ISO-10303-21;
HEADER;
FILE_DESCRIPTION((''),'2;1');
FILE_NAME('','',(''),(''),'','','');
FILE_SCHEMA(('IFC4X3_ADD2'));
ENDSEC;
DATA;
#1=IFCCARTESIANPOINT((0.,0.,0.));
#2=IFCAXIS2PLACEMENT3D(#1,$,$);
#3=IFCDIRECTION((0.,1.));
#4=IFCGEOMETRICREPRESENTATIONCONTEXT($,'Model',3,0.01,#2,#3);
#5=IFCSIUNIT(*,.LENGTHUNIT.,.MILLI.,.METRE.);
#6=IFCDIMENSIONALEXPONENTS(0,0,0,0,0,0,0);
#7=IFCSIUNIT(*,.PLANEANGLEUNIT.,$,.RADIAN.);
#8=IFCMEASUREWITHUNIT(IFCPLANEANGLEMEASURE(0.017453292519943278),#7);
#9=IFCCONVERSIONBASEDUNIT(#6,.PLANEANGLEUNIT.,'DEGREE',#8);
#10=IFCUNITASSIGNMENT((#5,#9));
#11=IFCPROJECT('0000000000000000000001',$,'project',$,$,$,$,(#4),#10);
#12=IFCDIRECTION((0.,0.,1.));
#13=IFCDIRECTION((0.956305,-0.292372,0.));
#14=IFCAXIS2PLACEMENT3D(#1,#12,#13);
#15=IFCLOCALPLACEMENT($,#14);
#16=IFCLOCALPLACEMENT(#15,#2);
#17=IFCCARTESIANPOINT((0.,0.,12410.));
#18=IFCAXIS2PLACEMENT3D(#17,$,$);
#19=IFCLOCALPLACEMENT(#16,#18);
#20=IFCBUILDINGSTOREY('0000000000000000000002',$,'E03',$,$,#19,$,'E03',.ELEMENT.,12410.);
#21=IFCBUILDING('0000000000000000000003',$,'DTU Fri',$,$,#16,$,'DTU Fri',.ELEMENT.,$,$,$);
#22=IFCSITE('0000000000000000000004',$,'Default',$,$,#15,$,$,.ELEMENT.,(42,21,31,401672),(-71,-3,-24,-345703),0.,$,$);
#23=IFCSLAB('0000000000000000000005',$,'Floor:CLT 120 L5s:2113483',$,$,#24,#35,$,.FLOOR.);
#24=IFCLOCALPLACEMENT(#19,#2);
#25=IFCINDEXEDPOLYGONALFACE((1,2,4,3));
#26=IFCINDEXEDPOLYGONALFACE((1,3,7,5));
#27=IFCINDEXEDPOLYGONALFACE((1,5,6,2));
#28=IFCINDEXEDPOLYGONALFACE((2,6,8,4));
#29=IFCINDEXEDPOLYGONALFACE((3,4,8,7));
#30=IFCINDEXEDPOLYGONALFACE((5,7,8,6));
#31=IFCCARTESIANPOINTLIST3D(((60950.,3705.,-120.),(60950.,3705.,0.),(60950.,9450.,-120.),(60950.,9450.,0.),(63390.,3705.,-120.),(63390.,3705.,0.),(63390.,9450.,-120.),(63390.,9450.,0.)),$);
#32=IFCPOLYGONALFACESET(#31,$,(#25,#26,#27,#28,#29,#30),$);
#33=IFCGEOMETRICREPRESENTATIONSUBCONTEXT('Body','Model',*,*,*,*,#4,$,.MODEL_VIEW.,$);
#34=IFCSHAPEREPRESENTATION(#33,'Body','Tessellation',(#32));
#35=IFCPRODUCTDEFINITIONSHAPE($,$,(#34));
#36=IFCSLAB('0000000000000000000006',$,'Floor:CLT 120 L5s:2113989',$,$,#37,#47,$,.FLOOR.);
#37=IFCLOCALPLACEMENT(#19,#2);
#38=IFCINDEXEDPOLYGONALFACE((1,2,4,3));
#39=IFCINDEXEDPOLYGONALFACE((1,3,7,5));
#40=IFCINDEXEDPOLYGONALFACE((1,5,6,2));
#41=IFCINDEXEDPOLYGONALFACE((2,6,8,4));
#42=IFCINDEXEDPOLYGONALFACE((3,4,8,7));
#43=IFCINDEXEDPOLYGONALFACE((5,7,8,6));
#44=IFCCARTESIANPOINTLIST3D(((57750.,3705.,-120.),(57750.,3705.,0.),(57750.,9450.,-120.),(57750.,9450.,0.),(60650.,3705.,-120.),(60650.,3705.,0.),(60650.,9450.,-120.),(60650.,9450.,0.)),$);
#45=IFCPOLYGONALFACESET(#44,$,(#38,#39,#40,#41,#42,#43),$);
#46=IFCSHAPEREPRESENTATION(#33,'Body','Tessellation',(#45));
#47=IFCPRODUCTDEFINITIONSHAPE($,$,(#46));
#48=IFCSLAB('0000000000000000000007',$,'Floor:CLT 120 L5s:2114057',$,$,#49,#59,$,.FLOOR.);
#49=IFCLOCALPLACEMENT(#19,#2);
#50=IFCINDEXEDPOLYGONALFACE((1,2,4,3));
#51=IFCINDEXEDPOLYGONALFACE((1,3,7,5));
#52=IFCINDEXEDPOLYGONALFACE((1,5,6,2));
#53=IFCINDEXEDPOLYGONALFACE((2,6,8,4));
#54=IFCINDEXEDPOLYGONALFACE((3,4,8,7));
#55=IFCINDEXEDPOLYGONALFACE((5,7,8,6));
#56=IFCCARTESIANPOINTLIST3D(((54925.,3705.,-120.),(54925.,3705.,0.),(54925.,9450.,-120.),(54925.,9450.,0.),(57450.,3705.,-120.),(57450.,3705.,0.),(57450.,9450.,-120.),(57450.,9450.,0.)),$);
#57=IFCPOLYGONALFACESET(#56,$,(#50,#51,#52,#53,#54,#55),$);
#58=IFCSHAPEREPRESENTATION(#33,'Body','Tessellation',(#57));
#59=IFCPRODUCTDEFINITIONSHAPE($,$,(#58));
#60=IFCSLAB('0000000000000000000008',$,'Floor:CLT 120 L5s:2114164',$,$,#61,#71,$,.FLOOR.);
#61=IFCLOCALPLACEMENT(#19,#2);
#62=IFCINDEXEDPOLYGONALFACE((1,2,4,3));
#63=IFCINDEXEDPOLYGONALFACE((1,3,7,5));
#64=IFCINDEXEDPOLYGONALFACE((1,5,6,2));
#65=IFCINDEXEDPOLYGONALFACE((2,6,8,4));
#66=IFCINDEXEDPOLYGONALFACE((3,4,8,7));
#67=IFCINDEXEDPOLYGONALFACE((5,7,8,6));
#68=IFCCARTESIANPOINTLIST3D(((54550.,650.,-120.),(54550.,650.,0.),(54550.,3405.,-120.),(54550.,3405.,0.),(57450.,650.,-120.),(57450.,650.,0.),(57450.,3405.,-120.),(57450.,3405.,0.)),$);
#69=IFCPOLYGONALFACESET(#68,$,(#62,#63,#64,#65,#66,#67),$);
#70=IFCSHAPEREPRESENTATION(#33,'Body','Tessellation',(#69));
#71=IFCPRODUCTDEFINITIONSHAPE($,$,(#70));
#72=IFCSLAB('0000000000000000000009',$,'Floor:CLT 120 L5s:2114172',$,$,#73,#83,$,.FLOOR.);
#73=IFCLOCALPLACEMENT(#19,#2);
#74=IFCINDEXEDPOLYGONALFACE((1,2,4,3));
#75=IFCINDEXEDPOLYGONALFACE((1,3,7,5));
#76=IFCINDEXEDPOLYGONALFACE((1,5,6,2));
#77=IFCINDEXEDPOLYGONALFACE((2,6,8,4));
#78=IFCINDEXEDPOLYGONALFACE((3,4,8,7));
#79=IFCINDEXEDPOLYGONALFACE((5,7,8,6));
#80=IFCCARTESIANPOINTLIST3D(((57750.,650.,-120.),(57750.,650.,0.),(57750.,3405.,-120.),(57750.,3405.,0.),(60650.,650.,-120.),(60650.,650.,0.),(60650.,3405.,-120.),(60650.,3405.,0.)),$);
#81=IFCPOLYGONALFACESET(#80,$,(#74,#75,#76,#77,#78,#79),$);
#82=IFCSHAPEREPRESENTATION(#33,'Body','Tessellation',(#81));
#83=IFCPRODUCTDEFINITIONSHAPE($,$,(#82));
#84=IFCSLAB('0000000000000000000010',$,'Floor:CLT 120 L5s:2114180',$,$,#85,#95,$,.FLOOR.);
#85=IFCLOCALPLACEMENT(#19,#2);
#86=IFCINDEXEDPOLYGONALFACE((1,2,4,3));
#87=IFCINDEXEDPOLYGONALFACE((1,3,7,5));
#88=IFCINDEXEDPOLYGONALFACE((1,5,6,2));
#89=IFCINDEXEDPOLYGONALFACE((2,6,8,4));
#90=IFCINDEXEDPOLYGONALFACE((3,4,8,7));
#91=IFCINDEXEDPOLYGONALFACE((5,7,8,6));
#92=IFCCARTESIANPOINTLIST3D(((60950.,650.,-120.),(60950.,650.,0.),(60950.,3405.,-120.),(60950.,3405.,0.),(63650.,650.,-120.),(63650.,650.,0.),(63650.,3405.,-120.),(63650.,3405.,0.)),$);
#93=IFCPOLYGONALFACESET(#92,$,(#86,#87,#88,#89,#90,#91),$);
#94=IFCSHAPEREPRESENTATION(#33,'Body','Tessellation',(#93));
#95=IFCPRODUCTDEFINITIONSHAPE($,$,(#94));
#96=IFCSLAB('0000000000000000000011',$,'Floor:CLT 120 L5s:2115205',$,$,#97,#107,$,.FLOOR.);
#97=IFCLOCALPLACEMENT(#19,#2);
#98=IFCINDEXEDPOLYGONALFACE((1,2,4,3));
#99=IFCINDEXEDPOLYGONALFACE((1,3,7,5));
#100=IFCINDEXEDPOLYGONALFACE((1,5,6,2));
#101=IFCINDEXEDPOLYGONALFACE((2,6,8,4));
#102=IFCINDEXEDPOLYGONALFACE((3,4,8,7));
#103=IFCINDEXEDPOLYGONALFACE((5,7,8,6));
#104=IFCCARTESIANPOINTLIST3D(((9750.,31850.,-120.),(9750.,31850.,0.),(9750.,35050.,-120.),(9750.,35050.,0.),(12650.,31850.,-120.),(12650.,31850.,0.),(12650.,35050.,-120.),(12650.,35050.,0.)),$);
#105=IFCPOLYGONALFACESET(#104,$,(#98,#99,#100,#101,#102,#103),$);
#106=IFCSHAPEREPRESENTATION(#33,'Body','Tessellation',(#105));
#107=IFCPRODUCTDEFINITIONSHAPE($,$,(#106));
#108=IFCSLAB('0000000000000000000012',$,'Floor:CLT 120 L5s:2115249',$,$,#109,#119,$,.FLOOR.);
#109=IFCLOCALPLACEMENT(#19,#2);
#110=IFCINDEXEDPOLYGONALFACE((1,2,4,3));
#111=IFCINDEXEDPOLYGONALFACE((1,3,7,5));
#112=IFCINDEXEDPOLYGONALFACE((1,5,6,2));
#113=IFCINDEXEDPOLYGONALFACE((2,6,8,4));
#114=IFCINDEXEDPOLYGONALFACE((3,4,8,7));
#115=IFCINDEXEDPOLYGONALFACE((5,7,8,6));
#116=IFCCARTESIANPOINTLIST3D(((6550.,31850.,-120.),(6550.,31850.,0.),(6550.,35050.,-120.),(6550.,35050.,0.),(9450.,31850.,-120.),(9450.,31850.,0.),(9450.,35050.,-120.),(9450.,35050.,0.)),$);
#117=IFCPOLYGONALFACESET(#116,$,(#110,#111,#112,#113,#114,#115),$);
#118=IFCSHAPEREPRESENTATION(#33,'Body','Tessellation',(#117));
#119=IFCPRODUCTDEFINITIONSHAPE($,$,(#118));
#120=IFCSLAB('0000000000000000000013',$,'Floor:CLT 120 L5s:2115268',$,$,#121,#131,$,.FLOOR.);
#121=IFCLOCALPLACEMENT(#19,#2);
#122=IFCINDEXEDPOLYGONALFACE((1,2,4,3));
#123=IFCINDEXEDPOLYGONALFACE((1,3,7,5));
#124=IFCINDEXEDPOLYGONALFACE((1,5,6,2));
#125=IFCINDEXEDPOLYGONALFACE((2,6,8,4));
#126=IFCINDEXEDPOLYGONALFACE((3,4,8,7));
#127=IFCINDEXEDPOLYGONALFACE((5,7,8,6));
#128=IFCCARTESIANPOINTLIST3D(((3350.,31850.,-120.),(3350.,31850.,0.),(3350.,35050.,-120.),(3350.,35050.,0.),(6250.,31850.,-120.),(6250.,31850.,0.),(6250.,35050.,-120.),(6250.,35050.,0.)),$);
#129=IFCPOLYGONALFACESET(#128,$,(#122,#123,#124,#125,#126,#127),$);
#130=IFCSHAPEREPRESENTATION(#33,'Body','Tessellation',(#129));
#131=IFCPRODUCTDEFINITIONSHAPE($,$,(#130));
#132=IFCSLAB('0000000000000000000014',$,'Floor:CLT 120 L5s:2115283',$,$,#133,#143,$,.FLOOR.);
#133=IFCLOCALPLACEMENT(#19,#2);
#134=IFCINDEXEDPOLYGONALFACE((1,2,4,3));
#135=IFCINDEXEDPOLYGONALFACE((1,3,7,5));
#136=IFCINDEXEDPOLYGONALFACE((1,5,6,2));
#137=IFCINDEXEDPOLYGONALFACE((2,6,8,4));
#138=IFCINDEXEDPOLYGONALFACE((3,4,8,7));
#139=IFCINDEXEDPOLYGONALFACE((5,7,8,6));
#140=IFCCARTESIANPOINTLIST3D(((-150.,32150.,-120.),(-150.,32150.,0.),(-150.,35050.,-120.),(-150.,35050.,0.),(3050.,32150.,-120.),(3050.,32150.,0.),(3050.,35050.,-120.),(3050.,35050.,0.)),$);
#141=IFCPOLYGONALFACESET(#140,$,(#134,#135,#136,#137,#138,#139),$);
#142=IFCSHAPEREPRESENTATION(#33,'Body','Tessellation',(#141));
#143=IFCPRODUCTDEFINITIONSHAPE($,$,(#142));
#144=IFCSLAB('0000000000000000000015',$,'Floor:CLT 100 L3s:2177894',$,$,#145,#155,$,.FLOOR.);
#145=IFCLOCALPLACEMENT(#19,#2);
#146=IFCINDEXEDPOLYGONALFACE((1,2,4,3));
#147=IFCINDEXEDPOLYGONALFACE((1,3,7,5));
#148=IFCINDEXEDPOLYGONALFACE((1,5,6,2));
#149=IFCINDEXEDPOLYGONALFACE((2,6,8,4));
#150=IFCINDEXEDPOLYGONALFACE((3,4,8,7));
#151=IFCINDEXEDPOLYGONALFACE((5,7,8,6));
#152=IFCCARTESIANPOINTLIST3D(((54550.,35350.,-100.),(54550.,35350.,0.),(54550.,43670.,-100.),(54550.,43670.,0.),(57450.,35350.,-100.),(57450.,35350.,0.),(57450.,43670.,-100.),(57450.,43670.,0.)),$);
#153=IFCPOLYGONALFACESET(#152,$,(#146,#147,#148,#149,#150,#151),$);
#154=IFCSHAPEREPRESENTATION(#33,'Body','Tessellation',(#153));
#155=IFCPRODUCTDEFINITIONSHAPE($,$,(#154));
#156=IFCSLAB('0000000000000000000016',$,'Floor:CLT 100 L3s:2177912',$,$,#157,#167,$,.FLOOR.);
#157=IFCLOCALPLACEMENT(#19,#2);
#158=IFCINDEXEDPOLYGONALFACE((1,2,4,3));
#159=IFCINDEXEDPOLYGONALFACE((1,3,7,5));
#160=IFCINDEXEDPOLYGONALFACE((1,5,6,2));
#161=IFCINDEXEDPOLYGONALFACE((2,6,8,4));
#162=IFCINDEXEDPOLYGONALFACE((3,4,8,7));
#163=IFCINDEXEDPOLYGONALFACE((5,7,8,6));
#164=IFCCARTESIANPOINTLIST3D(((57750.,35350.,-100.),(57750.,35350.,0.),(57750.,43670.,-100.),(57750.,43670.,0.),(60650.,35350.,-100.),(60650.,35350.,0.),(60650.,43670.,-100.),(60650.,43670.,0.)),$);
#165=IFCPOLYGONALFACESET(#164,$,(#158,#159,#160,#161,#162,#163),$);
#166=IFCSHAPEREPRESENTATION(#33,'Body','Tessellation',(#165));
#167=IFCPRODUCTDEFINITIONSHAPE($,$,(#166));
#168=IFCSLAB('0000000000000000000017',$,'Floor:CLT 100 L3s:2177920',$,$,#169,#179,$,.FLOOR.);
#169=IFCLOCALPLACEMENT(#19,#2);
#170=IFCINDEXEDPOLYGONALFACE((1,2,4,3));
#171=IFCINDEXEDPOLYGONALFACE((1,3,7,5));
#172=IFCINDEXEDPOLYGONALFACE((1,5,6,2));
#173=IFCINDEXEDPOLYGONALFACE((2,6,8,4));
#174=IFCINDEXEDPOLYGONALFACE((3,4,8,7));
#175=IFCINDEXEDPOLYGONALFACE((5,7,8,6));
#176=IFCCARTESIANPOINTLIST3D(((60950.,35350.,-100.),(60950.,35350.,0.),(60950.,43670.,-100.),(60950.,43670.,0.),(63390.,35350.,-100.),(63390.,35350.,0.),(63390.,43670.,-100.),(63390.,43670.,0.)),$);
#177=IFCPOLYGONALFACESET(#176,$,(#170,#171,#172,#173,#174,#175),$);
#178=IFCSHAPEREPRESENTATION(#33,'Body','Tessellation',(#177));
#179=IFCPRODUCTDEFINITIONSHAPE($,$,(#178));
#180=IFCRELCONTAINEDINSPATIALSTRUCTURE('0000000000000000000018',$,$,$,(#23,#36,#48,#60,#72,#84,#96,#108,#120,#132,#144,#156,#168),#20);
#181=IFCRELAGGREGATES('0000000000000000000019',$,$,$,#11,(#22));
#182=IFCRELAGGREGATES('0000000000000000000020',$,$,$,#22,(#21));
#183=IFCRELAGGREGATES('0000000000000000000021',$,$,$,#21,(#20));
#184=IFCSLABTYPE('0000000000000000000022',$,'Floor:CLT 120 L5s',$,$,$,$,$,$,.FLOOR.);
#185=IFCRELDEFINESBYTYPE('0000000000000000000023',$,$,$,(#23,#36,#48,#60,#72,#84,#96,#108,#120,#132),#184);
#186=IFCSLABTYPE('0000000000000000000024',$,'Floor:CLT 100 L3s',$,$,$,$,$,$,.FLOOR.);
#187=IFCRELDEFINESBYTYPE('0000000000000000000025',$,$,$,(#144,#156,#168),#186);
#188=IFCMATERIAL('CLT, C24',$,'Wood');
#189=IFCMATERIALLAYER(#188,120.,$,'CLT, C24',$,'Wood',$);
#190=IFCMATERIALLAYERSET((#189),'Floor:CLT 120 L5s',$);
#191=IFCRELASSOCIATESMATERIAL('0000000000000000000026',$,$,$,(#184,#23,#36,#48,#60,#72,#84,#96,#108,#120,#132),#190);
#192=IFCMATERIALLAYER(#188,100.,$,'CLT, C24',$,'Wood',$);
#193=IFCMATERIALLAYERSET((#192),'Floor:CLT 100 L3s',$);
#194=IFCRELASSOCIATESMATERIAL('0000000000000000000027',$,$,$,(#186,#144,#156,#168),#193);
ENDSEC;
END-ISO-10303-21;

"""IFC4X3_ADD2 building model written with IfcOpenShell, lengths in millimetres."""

from ifc_helpers import new_model, entity, si_unit, converted_unit, direction, frame, frame_2d, origin, origin_2d_with_axis, place, context, subcontext, project, spatial, rectangle, extrude, material, layer, layer_set, layer_usage, type_object, element, save


model = new_model("IFC4X3_ADD2")

# Units and contexts
model_context = context("Model", 3, precision=0.01, world=origin(), true_north=direction((0.0, 1.0)))
body_context = subcontext(model_context, "Body", "Model", "MODEL_VIEW")
ifc_project = project(units=[si_unit("LENGTHUNIT", "METRE", prefix="MILLI"), converted_unit("PLANEANGLEUNIT", "DEGREE", entity("IfcPlaneAngleMeasure", 0.017453292519943278), si_unit("PLANEANGLEUNIT", "RADIAN"), dimensions=[0, 0, 0, 0, 0, 0, 0])], contexts=[model_context])

# Site, building, storey
site_placement = place(None, frame((0.0, 0.0, 0.0), z_axis=(0.0, 0.0, 1.0), x_axis=(0.956305, -0.292372, 0.0)))
site = spatial("IfcSite", under=ifc_project, at=site_placement, Name="Default", CompositionType="ELEMENT", RefLatitude=(42, 21, 31, 401672), RefLongitude=(-71, -3, -24, -345703), RefElevation=0.0)
building_placement = place(site_placement, origin())
building = spatial("IfcBuilding", under=site, at=building_placement, Name="DTU Fri", LongName="DTU Fri", CompositionType="ELEMENT")
storey_placement = place(building_placement, frame((0.0, 0.0, 12410.0)))
storey = spatial("IfcBuildingStorey", under=building, at=storey_placement, Name="E03", LongName="E03", CompositionType="ELEMENT", Elevation=12410.0)

# Slabs
ifc_material = material(Name="CLT, C24", Category="Wood")
ifc_layer_1 = layer(ifc_material, 120.0, Name="CLT, C24", Category="Wood")
ifc_layer_set_1 = layer_set([ifc_layer_1], Name="Floor:CLT 120 L5s")
ifc_layer_usage_1 = layer_usage(ifc_layer_set_1, "AXIS3", "POSITIVE", 0.0)
slab_type_1 = type_object("IfcSlabType", Name="Floor:CLT 120 L5s", PredefinedType="FLOOR", material=ifc_layer_set_1)
slab_1_placement = place(storey_placement, origin())
element("IfcSlab", 1, at=slab_1_placement, inside=storey, type_object=slab_type_1, material=ifc_layer_usage_1, Name="Floor:CLT 120 L5s:2113483", PredefinedType="FLOOR", context=body_context, shape_type="SweptSolid", body=[
    extrude(rectangle(XDim=5745.0, YDim=2440.0, at=frame_2d((0.0, 0.0), x_axis=(1.0, 0.0))), frame((62170.0, 6577.5, 0.0), z_axis=(0.0, 0.0, -1.0), x_axis=(0.0, 1.0, 0.0)), (0.0, 0.0, 1.0), 120.0),
])
ifc_layer_usage_2 = layer_usage(ifc_layer_set_1, "AXIS3", "POSITIVE", 0.0)
slab_2_placement = place(storey_placement, origin())
element("IfcSlab", 2, at=slab_2_placement, inside=storey, type_object=slab_type_1, material=ifc_layer_usage_2, Name="Floor:CLT 120 L5s:2113989", PredefinedType="FLOOR", context=body_context, shape_type="SweptSolid", body=[
    extrude(rectangle(XDim=5745.0, YDim=2900.0, at=frame_2d((0.0, 0.0), x_axis=(1.0, 0.0))), frame((59200.0, 6577.5, 0.0), z_axis=(0.0, 0.0, -1.0), x_axis=(0.0, 1.0, 0.0)), (0.0, 0.0, 1.0), 120.0),
])
ifc_layer_usage_3 = layer_usage(ifc_layer_set_1, "AXIS3", "POSITIVE", 0.0)
slab_3_placement = place(storey_placement, origin())
element("IfcSlab", 3, at=slab_3_placement, inside=storey, type_object=slab_type_1, material=ifc_layer_usage_3, Name="Floor:CLT 120 L5s:2114057", PredefinedType="FLOOR", context=body_context, shape_type="SweptSolid", body=[
    extrude(rectangle(XDim=5745.0, YDim=2525.0, at=frame_2d((0.0, 0.0), x_axis=(1.0, 0.0))), frame((56187.5, 6577.5, 0.0), z_axis=(0.0, 0.0, -1.0), x_axis=(0.0, 1.0, 0.0)), (0.0, 0.0, 1.0), 120.0),
])
ifc_layer_usage_4 = layer_usage(ifc_layer_set_1, "AXIS3", "POSITIVE", 0.0)
slab_4_placement = place(storey_placement, origin())
element("IfcSlab", 4, at=slab_4_placement, inside=storey, type_object=slab_type_1, material=ifc_layer_usage_4, Name="Floor:CLT 120 L5s:2114164", PredefinedType="FLOOR", context=body_context, shape_type="SweptSolid", body=[
    extrude(rectangle(XDim=2755.0, YDim=2900.0, at=origin_2d_with_axis()), frame((56000.0, 2027.5, 0.0), z_axis=(0.0, 0.0, -1.0), x_axis=(0.0, 1.0, 0.0)), (0.0, 0.0, 1.0), 120.0),
])
ifc_layer_usage_5 = layer_usage(ifc_layer_set_1, "AXIS3", "POSITIVE", 0.0)
slab_5_placement = place(storey_placement, origin())
element("IfcSlab", 5, at=slab_5_placement, inside=storey, type_object=slab_type_1, material=ifc_layer_usage_5, Name="Floor:CLT 120 L5s:2114172", PredefinedType="FLOOR", context=body_context, shape_type="SweptSolid", body=[
    extrude(rectangle(XDim=2755.0, YDim=2900.0, at=frame_2d((0.0, 0.0), x_axis=(1.0, 0.0))), frame((59200.0, 2027.5, 0.0), z_axis=(0.0, 0.0, -1.0), x_axis=(0.0, 1.0, 0.0)), (0.0, 0.0, 1.0), 120.0),
])
ifc_layer_usage_6 = layer_usage(ifc_layer_set_1, "AXIS3", "POSITIVE", 0.0)
slab_6_placement = place(storey_placement, origin())
element("IfcSlab", 6, at=slab_6_placement, inside=storey, type_object=slab_type_1, material=ifc_layer_usage_6, Name="Floor:CLT 120 L5s:2114180", PredefinedType="FLOOR", context=body_context, shape_type="SweptSolid", body=[
    extrude(rectangle(XDim=2755.0, YDim=2700.0, at=frame_2d((0.0, 0.0), x_axis=(1.0, 0.0))), frame((62300.0, 2027.5, 0.0), z_axis=(0.0, 0.0, -1.0), x_axis=(0.0, 1.0, 0.0)), (0.0, 0.0, 1.0), 120.0),
])
ifc_layer_usage_7 = layer_usage(ifc_layer_set_1, "AXIS3", "POSITIVE", 0.0)
slab_7_placement = place(storey_placement, origin())
element("IfcSlab", 7, at=slab_7_placement, inside=storey, type_object=slab_type_1, material=ifc_layer_usage_7, Name="Floor:CLT 120 L5s:2115205", PredefinedType="FLOOR", context=body_context, shape_type="SweptSolid", body=[
    extrude(rectangle(XDim=3200.0, YDim=2900.0, at=frame_2d((0.0, 0.0), x_axis=(1.0, 0.0))), frame((11200.0, 33450.0, 0.0), z_axis=(0.0, 0.0, -1.0), x_axis=(0.0, 1.0, 0.0)), (0.0, 0.0, 1.0), 120.0),
])
ifc_layer_usage_8 = layer_usage(ifc_layer_set_1, "AXIS3", "POSITIVE", 0.0)
slab_8_placement = place(storey_placement, origin())
element("IfcSlab", 8, at=slab_8_placement, inside=storey, type_object=slab_type_1, material=ifc_layer_usage_8, Name="Floor:CLT 120 L5s:2115249", PredefinedType="FLOOR", context=body_context, shape_type="SweptSolid", body=[
    extrude(rectangle(XDim=3200.0, YDim=2900.0, at=frame_2d((0.0, 0.0), x_axis=(1.0, 0.0))), frame((8000.0, 33450.0, 0.0), z_axis=(0.0, 0.0, -1.0), x_axis=(0.0, 1.0, 0.0)), (0.0, 0.0, 1.0), 120.0),
])
ifc_layer_usage_9 = layer_usage(ifc_layer_set_1, "AXIS3", "POSITIVE", 0.0)
slab_9_placement = place(storey_placement, origin())
element("IfcSlab", 9, at=slab_9_placement, inside=storey, type_object=slab_type_1, material=ifc_layer_usage_9, Name="Floor:CLT 120 L5s:2115268", PredefinedType="FLOOR", context=body_context, shape_type="SweptSolid", body=[
    extrude(rectangle(XDim=3200.0, YDim=2900.0, at=frame_2d((0.0, 0.0), x_axis=(1.0, 0.0))), frame((4800.0, 33450.0, 0.0), z_axis=(0.0, 0.0, -1.0), x_axis=(0.0, 1.0, 0.0)), (0.0, 0.0, 1.0), 120.0),
])
ifc_layer_usage_10 = layer_usage(ifc_layer_set_1, "AXIS3", "POSITIVE", 0.0)
slab_10_placement = place(storey_placement, origin())
element("IfcSlab", 10, at=slab_10_placement, inside=storey, type_object=slab_type_1, material=ifc_layer_usage_10, Name="Floor:CLT 120 L5s:2115283", PredefinedType="FLOOR", context=body_context, shape_type="SweptSolid", body=[
    extrude(rectangle(XDim=2900.0, YDim=3200.0, at=frame_2d((0.0, 0.0), x_axis=(1.0, 0.0))), frame((1450.0, 33600.0, 0.0), z_axis=(0.0, 0.0, -1.0), x_axis=(0.0, 1.0, 0.0)), (0.0, 0.0, 1.0), 120.0),
])
ifc_layer_2 = layer(ifc_material, 100.0, Name="CLT, C24", Category="Wood")
ifc_layer_set_2 = layer_set([ifc_layer_2], Name="Floor:CLT 100 L3s")
ifc_layer_usage_11 = layer_usage(ifc_layer_set_2, "AXIS3", "POSITIVE", 0.0)
slab_type_2 = type_object("IfcSlabType", Name="Floor:CLT 100 L3s", PredefinedType="FLOOR", material=ifc_layer_set_2)
slab_11_placement = place(storey_placement, origin())
element("IfcSlab", 11, at=slab_11_placement, inside=storey, type_object=slab_type_2, material=ifc_layer_usage_11, Name="Floor:CLT 100 L3s:2177894", PredefinedType="FLOOR", context=body_context, shape_type="SweptSolid", body=[
    extrude(rectangle(XDim=8320.0, YDim=2900.0, at=frame_2d((0.0, 0.0), x_axis=(1.0, 0.0))), frame((56000.0, 39510.0, 0.0), z_axis=(0.0, 0.0, -1.0), x_axis=(0.0, 1.0, 0.0)), (0.0, 0.0, 1.0), 100.0),
])
ifc_layer_usage_12 = layer_usage(ifc_layer_set_2, "AXIS3", "POSITIVE", 0.0)
slab_12_placement = place(storey_placement, origin())
element("IfcSlab", 12, at=slab_12_placement, inside=storey, type_object=slab_type_2, material=ifc_layer_usage_12, Name="Floor:CLT 100 L3s:2177912", PredefinedType="FLOOR", context=body_context, shape_type="SweptSolid", body=[
    extrude(rectangle(XDim=8320.0, YDim=2900.0, at=frame_2d((0.0, 0.0), x_axis=(1.0, 0.0))), frame((59200.0, 39510.0, 0.0), z_axis=(0.0, 0.0, -1.0), x_axis=(0.0, 1.0, 0.0)), (0.0, 0.0, 1.0), 100.0),
])
ifc_layer_usage_13 = layer_usage(ifc_layer_set_2, "AXIS3", "POSITIVE", 0.0)
slab_13_placement = place(storey_placement, origin())
element("IfcSlab", 13, at=slab_13_placement, inside=storey, type_object=slab_type_2, material=ifc_layer_usage_13, Name="Floor:CLT 100 L3s:2177920", PredefinedType="FLOOR", context=body_context, shape_type="SweptSolid", body=[
    extrude(rectangle(XDim=8320.0, YDim=2440.0, at=frame_2d((0.0, 0.0), x_axis=(1.0, 0.0))), frame((62170.0, 39510.0, 0.0), z_axis=(0.0, 0.0, -1.0), x_axis=(0.0, 1.0, 0.0)), (0.0, 0.0, 1.0), 100.0),
])

save(model, "model.ifc")
